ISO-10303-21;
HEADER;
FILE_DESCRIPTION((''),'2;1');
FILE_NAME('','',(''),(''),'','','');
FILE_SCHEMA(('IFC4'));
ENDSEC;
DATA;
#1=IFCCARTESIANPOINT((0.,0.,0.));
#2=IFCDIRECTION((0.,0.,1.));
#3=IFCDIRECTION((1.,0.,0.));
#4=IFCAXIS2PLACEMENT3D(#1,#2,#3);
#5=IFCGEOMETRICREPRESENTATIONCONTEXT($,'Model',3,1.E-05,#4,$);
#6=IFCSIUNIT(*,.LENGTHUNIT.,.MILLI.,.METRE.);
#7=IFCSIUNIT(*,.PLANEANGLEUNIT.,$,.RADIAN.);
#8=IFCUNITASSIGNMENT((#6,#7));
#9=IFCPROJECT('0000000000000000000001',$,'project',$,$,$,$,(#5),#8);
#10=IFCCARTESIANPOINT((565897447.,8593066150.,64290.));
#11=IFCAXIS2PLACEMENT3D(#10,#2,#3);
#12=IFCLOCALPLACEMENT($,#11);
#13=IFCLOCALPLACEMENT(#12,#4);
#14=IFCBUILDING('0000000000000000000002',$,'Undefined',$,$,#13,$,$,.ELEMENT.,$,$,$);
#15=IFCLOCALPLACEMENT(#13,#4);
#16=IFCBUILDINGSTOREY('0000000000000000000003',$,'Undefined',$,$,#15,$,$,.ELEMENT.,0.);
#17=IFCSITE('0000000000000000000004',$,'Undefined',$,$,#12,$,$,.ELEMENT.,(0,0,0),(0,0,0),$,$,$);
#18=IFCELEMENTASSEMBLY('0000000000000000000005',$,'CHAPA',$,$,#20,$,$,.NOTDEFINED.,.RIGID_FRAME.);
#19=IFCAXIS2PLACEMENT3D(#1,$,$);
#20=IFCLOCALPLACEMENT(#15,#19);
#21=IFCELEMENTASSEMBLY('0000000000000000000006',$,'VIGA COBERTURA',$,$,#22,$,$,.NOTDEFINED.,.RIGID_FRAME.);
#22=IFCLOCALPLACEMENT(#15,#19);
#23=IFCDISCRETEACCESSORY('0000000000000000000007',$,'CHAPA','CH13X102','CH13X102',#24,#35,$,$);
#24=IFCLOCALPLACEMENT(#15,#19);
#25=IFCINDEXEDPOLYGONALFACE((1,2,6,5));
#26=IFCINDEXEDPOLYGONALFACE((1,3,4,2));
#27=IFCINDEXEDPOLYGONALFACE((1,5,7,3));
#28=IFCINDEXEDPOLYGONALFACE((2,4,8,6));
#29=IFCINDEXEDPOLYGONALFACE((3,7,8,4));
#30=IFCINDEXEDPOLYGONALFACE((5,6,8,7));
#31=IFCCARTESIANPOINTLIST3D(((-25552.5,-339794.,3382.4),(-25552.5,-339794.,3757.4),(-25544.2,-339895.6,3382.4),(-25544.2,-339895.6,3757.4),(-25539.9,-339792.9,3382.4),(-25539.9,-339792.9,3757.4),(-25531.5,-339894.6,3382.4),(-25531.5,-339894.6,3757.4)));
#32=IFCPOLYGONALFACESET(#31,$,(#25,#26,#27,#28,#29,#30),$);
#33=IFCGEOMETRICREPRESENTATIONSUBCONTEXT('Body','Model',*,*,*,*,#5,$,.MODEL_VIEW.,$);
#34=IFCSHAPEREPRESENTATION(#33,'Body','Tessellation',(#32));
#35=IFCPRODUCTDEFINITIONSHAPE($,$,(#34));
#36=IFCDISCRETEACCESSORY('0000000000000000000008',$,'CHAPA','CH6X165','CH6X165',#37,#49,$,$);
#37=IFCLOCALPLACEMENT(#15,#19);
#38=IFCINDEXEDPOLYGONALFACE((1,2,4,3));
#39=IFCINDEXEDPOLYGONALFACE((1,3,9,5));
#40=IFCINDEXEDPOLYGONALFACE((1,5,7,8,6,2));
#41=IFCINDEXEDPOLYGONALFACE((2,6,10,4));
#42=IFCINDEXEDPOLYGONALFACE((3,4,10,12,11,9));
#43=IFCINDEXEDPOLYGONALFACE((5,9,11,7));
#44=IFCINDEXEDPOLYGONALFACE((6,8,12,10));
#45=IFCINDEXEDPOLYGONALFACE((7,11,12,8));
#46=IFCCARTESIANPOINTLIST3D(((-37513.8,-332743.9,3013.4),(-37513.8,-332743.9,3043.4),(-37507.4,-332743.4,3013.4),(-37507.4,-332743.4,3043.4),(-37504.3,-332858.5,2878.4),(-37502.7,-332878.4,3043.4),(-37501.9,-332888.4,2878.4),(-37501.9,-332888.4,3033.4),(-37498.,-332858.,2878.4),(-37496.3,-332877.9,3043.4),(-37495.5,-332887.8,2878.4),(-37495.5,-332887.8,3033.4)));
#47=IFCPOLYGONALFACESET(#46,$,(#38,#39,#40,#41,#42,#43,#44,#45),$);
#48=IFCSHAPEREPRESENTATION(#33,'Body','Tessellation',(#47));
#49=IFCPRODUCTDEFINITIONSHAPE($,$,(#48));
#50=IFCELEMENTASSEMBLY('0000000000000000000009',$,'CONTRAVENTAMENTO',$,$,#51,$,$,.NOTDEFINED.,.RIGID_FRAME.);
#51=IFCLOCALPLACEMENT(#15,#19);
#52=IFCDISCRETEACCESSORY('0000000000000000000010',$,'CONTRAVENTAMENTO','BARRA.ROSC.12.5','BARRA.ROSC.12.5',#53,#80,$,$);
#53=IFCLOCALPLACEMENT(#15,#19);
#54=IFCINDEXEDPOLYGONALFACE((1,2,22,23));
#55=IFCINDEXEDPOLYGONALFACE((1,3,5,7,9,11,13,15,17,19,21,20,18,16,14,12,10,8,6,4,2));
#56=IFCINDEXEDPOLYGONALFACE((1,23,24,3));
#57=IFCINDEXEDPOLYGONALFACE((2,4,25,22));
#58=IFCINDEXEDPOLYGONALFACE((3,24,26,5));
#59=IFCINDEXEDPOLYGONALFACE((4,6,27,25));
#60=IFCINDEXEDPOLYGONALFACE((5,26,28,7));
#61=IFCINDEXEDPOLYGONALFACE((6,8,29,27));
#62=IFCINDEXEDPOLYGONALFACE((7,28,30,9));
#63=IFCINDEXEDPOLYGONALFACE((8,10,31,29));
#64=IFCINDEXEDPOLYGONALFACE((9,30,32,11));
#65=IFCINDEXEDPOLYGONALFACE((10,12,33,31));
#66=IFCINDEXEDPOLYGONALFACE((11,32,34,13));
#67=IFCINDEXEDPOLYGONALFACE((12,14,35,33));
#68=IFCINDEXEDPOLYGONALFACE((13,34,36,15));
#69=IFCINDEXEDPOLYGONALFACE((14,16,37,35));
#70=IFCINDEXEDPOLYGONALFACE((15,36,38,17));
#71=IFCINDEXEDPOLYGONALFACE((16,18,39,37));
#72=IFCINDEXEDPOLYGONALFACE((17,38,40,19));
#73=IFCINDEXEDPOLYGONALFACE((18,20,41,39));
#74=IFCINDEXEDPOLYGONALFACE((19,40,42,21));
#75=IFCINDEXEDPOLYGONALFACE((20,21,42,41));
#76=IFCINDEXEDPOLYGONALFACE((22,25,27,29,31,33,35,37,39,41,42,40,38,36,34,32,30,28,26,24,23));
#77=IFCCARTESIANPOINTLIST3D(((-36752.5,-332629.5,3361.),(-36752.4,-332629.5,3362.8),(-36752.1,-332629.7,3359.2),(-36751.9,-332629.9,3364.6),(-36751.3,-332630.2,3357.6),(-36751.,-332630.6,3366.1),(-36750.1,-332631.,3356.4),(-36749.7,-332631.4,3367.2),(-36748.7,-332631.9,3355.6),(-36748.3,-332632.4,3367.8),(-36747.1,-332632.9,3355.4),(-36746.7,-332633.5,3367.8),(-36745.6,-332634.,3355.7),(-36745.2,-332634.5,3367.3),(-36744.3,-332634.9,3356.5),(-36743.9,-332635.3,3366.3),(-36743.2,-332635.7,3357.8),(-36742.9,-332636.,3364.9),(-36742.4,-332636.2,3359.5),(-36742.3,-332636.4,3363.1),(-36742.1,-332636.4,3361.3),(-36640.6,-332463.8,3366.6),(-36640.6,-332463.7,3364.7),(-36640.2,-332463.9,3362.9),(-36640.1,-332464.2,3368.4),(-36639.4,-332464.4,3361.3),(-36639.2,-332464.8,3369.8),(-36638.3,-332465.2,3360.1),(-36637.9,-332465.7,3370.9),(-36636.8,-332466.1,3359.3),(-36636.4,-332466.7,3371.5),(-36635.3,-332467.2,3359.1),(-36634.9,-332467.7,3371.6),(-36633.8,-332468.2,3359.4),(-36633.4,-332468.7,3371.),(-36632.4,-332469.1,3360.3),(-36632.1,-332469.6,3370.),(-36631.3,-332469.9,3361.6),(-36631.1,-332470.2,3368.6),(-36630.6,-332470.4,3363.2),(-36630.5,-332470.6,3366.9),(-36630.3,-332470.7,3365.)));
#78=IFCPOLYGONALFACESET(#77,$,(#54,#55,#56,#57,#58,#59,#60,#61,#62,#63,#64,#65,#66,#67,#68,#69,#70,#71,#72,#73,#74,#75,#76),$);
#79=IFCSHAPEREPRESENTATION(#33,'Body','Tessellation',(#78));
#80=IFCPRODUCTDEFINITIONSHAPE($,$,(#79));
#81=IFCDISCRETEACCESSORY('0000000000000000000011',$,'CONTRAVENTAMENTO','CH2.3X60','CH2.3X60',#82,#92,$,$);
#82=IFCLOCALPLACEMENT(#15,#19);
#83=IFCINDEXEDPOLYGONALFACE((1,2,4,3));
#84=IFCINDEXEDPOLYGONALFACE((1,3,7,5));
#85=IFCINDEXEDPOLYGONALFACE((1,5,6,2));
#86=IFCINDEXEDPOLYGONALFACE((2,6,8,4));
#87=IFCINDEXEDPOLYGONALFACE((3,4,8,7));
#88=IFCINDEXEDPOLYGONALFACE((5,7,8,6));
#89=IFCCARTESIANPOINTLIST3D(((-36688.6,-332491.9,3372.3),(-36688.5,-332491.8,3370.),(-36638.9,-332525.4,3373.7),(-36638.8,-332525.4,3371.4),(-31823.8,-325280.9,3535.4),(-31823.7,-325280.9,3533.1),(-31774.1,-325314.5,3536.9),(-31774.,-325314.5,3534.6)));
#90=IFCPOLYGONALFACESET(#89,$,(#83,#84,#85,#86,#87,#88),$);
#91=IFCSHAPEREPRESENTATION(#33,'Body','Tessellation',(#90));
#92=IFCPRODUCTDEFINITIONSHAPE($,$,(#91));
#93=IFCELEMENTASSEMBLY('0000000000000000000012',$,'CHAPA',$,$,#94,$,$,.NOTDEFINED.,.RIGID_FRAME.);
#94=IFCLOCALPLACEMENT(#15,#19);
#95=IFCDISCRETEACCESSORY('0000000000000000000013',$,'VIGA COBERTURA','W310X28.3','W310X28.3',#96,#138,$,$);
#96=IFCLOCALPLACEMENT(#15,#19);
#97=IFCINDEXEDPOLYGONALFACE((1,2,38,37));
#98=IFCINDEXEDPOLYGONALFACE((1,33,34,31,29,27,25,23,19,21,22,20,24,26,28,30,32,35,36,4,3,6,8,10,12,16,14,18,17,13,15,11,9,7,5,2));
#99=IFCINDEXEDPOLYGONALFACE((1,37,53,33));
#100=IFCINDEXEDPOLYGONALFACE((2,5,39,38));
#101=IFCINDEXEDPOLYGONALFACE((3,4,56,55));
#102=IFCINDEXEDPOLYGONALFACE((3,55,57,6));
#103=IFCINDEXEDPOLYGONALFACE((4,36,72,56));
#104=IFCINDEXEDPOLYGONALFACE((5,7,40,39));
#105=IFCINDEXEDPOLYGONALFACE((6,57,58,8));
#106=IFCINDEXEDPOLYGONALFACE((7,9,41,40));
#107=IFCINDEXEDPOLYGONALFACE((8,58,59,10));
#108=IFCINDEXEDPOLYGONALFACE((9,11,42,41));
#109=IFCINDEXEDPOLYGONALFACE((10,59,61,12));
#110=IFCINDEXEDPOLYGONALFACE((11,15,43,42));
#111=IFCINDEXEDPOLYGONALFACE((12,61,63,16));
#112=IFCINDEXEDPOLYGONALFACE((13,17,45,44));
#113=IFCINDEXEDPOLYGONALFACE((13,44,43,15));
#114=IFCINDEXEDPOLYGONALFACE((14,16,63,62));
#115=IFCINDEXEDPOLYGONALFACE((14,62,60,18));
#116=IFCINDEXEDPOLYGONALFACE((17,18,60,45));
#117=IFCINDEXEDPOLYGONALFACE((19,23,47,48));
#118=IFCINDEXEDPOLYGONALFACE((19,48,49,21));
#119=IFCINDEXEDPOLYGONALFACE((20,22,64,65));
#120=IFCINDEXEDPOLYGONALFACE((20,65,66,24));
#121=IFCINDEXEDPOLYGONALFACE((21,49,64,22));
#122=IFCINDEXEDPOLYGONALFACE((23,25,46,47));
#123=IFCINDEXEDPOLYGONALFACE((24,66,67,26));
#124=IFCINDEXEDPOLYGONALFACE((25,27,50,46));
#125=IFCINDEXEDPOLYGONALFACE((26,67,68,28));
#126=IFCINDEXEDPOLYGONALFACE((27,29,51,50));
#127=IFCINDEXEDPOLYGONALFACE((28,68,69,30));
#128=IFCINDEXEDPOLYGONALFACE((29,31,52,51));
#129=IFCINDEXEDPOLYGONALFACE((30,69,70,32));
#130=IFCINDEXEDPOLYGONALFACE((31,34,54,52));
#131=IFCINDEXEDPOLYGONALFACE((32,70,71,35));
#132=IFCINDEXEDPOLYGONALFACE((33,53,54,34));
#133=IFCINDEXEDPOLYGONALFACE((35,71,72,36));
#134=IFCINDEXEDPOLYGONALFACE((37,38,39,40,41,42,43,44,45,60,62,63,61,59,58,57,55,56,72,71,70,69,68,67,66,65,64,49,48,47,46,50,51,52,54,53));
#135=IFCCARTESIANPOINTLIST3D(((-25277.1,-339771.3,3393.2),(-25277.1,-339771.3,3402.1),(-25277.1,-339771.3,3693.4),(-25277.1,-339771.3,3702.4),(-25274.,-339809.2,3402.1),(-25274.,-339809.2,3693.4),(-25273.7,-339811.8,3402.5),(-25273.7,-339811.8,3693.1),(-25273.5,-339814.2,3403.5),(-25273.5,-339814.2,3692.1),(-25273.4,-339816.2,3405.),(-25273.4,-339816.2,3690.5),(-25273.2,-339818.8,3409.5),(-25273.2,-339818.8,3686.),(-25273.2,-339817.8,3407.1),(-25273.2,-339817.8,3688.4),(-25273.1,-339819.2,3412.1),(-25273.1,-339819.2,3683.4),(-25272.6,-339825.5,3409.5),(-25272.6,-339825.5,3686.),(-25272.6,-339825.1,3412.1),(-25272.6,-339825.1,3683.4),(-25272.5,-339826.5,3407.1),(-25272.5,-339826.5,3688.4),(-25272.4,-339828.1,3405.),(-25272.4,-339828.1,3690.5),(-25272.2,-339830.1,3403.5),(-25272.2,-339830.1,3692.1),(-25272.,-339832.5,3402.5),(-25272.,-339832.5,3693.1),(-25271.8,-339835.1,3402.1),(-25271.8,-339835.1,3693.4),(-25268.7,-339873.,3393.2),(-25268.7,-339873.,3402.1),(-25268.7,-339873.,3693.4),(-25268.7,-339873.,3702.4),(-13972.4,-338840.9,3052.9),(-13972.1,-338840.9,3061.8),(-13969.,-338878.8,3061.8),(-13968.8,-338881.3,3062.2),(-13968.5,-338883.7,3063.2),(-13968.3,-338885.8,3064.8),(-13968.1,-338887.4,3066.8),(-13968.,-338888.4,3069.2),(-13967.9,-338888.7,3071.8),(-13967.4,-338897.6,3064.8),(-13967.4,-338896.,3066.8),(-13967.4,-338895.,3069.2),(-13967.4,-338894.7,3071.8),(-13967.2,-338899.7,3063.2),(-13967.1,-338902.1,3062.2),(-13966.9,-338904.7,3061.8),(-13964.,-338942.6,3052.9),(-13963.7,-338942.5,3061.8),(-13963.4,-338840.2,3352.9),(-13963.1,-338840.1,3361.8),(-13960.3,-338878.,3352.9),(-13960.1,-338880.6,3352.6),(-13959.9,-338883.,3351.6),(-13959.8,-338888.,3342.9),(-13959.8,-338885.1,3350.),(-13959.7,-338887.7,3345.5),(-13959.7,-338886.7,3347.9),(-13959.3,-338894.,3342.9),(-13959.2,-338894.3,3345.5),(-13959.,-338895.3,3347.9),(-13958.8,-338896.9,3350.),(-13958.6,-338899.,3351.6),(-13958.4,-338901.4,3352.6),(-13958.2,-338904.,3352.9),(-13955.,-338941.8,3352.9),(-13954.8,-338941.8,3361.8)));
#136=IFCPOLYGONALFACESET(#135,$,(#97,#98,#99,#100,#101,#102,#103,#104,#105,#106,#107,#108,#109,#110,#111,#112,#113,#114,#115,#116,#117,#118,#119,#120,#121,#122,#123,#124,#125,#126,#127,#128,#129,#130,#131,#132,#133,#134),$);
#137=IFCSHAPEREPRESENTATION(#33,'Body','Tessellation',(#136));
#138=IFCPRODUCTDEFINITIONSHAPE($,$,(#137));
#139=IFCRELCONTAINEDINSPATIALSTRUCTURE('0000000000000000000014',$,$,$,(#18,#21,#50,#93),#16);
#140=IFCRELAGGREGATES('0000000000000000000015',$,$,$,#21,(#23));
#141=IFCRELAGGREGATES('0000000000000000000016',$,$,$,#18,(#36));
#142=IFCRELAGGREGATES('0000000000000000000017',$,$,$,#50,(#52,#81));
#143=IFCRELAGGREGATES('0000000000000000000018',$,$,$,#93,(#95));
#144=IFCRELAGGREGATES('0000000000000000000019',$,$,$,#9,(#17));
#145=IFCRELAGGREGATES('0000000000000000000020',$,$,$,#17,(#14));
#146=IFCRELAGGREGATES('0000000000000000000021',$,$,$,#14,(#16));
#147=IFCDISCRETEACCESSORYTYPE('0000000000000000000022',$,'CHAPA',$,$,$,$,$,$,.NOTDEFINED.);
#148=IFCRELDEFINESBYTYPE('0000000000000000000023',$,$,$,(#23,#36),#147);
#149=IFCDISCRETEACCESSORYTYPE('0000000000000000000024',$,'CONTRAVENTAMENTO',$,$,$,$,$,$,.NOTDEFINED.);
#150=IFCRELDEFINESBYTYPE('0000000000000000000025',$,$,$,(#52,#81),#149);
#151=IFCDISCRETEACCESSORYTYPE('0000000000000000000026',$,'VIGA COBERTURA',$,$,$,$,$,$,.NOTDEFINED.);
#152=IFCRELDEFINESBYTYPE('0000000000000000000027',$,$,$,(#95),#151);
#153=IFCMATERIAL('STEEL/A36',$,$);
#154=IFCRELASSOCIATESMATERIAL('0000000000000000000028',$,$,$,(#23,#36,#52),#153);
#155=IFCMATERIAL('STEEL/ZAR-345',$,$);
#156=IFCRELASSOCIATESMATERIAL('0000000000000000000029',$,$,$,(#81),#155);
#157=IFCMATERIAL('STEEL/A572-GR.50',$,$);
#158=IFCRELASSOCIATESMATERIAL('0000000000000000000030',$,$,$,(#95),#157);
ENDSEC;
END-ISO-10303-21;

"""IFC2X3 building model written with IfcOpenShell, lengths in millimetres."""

from ifc_helpers import new_model, si_unit, frame, origin_with_axes, origin_2d_with_axis, place, context, subcontext, project, spatial, polyline, circle, i_section, outline, extrude, clip, halfspace, material, type_object, element, aggregate, save


model = new_model("IFC2X3")

# Units and contexts
model_context = context("Model", 3, precision=1e-05, world=origin_with_axes())
body_context = subcontext(model_context, "Body", "Model", "MODEL_VIEW")
ifc_project = project(units=[si_unit("LENGTHUNIT", "METRE", prefix="MILLI"), si_unit("PLANEANGLEUNIT", "RADIAN")], contexts=[model_context])

# Site, building, storey
site_placement = place(None, frame((565897447.0, 8593066150.0, 64290.0), z_axis=(0.0, 0.0, 1.0), x_axis=(1.0, 0.0, 0.0)))
site = spatial("IfcSite", under=ifc_project, at=site_placement, Name="Undefined", CompositionType="ELEMENT", RefLatitude=(0, 0, 0), RefLongitude=(0, 0, 0))
building_placement = place(site_placement, origin_with_axes())
building = spatial("IfcBuilding", under=site, at=building_placement, Name="Undefined", CompositionType="ELEMENT")
storey_placement = place(building_placement, origin_with_axes())
storey = spatial("IfcBuildingStorey", under=building, at=storey_placement, Name="Undefined", CompositionType="ELEMENT", Elevation=0.0)

# Shared definitions
ifc_material_1 = material(Name="STEEL/A572-GR.50")

# Element assemblies
ifc_material_2 = material(Name="STEEL/A36")
assembly_1_placement = place(storey_placement, origin_with_axes())
assembly_1 = element("IfcElementAssembly", 1, at=assembly_1_placement, inside=storey, Name="CHAPA", AssemblyPlace="NOTDEFINED", PredefinedType="RIGID_FRAME")
assembly_2_placement = place(storey_placement, origin_with_axes())
assembly_2 = element("IfcElementAssembly", 2, at=assembly_2_placement, inside=storey, Name="VIGA COBERTURA", AssemblyPlace="NOTDEFINED", PredefinedType="RIGID_FRAME")

# Discrete accessories
discrete_accessory_type_1 = type_object("IfcDiscreteAccessoryType", Name="CHAPA")
discrete_accessory_1_placement = place(assembly_2_placement, frame((-25542.0, -339844.3, 3757.4), z_axis=(0.99663, 0.082025, 0.0), x_axis=(0.0, 0.0, -1.0)))
discrete_accessory_1 = element("IfcDiscreteAccessory", 3, at=discrete_accessory_1_placement, type_object=discrete_accessory_type_1, material=ifc_material_2, Name="CHAPA", Description="CH13X102", ObjectType="CH13X102", context=body_context, shape_type="SweptSolid", body=[
    extrude(outline(polyline([(375.0, 51.0), (375.0, -51.0), (0.0, -51.0), (0.0, 51.0), (375.0, 51.0)])), frame((0.0, 0.0, -6.3), z_axis=(0.0, 0.0, 1.0), x_axis=(1.0, 0.0, 0.0)), (0.0, 0.0, 1.0), 12.7),
])
aggregate(assembly_2, [discrete_accessory_1])
discrete_accessory_2_placement = place(assembly_1_placement, frame((-37498.7, -332888.1, 3043.4), z_axis=(0.99663, 0.082025, -0.000004), x_axis=(-0.000004, 0.0, -1.0)))
discrete_accessory_2 = element("IfcDiscreteAccessory", 4, at=discrete_accessory_2_placement, type_object=discrete_accessory_type_1, material=ifc_material_2, Name="CHAPA", Description="CH6X165", ObjectType="CH6X165", context=body_context, shape_type="SweptSolid", body=[
    extrude(outline(polyline([(0.0, 10.0), (10.0, 0.0), (165.0, 0.0), (165.0, 30.0), (30.0, 145.0), (0.0, 145.0), (0.0, 10.0)])), frame((0.0, 0.0, -3.2), z_axis=(0.0, 0.0, 1.0), x_axis=(1.0, 0.0, 0.0)), (0.0, 0.0, 1.0), 6.4),
])
aggregate(assembly_1, [discrete_accessory_2])

# Element assembly, discrete accessories
assembly_3_placement = place(storey_placement, origin_with_axes())
assembly_3 = element("IfcElementAssembly", 5, at=assembly_3_placement, inside=storey, Name="CONTRAVENTAMENTO", AssemblyPlace="NOTDEFINED", PredefinedType="RIGID_FRAME")
discrete_accessory_type_2 = type_object("IfcDiscreteAccessoryType", Name="CONTRAVENTAMENTO")
discrete_accessory_3_placement = place(assembly_3_placement, frame((-36747.3, -332632.9, 3361.6), z_axis=(0.828505, -0.559481, 0.023679), x_axis=(0.559171, 0.82884, 0.018758)))
discrete_accessory_3 = element("IfcDiscreteAccessory", 6, at=discrete_accessory_3_placement, type_object=discrete_accessory_type_2, material=ifc_material_2, Name="CONTRAVENTAMENTO", Description="BARRA.ROSC.12.5", ObjectType="BARRA.ROSC.12.5", context=body_context, shape_type="SweptSolid", body=[
    extrude(circle(Radius=6.2, at=origin_2d_with_axis()), frame((200.0, 0.0, 0.0), z_axis=(-1.0, 0.0, 0.0), x_axis=(0.0, -1.0, 0.0)), (0.0, 0.0, 1.0), 200.0),
])
ifc_material_3 = material(Name="STEEL/ZAR-345")
discrete_accessory_4_placement = place(assembly_3_placement, frame((-36663.7, -332508.6, 3371.8), z_axis=(0.030121, 0.0023, -0.999544), x_axis=(0.559171, 0.82884, 0.018758)))
discrete_accessory_4 = element("IfcDiscreteAccessory", 7, at=discrete_accessory_4_placement, type_object=discrete_accessory_type_2, material=ifc_material_3, Name="CONTRAVENTAMENTO", Description="CH2.3X60", ObjectType="CH2.3X60", context=body_context, shape_type="SweptSolid", body=[
    extrude(outline(polyline([(8700.0, -30.0), (0.0, -30.0), (0.0, 30.0), (8700.0, 30.0), (8700.0, -30.0)])), frame((0.0, 0.0, -1.1), z_axis=(0.0, 0.0, 1.0), x_axis=(1.0, 0.0, 0.0)), (0.0, 0.0, 1.0), 2.3),
])
aggregate(assembly_3, [discrete_accessory_3, discrete_accessory_4])

# Element assembly, discrete accessory
assembly_4_placement = place(storey_placement, origin_with_axes())
assembly_4 = element("IfcElementAssembly", 8, at=assembly_4_placement, inside=storey, Name="CHAPA", AssemblyPlace="NOTDEFINED", PredefinedType="RIGID_FRAME")
discrete_accessory_type_3 = type_object("IfcDiscreteAccessoryType", Name="VIGA COBERTURA")
discrete_accessory_5_placement = place(assembly_4_placement, frame((-25290.2, -339823.6, 3548.3), z_axis=(-0.029885, -0.00246, -0.99955), x_axis=(0.996182, 0.081989, -0.029987)))
discrete_accessory_5 = element("IfcDiscreteAccessory", 9, at=discrete_accessory_5_placement, type_object=discrete_accessory_type_3, material=ifc_material_1, Name="VIGA COBERTURA", Description="W310X28.3", ObjectType="W310X28.3", context=body_context, shape_type="Clipping", body=[
    clip(extrude(i_section(OverallWidth=102.0, OverallDepth=309.0, WebThickness=6.0, FlangeThickness=8.9, FilletRadius=10.0, at=origin_2d_with_axis()), frame((11370.0, 0.0, 0.0), z_axis=(-1.0, 0.0, 0.0), x_axis=(0.0, -1.0, 0.0)), (0.0, 0.0, 1.0), 11370.0), halfspace(frame((12.7, -51.0, -154.5), z_axis=(-0.99955, 0.0, 0.029987), x_axis=(0.0, 1.0, 0.0)), False)),
])
aggregate(assembly_4, [discrete_accessory_5])

save(model, "model.ifc")
